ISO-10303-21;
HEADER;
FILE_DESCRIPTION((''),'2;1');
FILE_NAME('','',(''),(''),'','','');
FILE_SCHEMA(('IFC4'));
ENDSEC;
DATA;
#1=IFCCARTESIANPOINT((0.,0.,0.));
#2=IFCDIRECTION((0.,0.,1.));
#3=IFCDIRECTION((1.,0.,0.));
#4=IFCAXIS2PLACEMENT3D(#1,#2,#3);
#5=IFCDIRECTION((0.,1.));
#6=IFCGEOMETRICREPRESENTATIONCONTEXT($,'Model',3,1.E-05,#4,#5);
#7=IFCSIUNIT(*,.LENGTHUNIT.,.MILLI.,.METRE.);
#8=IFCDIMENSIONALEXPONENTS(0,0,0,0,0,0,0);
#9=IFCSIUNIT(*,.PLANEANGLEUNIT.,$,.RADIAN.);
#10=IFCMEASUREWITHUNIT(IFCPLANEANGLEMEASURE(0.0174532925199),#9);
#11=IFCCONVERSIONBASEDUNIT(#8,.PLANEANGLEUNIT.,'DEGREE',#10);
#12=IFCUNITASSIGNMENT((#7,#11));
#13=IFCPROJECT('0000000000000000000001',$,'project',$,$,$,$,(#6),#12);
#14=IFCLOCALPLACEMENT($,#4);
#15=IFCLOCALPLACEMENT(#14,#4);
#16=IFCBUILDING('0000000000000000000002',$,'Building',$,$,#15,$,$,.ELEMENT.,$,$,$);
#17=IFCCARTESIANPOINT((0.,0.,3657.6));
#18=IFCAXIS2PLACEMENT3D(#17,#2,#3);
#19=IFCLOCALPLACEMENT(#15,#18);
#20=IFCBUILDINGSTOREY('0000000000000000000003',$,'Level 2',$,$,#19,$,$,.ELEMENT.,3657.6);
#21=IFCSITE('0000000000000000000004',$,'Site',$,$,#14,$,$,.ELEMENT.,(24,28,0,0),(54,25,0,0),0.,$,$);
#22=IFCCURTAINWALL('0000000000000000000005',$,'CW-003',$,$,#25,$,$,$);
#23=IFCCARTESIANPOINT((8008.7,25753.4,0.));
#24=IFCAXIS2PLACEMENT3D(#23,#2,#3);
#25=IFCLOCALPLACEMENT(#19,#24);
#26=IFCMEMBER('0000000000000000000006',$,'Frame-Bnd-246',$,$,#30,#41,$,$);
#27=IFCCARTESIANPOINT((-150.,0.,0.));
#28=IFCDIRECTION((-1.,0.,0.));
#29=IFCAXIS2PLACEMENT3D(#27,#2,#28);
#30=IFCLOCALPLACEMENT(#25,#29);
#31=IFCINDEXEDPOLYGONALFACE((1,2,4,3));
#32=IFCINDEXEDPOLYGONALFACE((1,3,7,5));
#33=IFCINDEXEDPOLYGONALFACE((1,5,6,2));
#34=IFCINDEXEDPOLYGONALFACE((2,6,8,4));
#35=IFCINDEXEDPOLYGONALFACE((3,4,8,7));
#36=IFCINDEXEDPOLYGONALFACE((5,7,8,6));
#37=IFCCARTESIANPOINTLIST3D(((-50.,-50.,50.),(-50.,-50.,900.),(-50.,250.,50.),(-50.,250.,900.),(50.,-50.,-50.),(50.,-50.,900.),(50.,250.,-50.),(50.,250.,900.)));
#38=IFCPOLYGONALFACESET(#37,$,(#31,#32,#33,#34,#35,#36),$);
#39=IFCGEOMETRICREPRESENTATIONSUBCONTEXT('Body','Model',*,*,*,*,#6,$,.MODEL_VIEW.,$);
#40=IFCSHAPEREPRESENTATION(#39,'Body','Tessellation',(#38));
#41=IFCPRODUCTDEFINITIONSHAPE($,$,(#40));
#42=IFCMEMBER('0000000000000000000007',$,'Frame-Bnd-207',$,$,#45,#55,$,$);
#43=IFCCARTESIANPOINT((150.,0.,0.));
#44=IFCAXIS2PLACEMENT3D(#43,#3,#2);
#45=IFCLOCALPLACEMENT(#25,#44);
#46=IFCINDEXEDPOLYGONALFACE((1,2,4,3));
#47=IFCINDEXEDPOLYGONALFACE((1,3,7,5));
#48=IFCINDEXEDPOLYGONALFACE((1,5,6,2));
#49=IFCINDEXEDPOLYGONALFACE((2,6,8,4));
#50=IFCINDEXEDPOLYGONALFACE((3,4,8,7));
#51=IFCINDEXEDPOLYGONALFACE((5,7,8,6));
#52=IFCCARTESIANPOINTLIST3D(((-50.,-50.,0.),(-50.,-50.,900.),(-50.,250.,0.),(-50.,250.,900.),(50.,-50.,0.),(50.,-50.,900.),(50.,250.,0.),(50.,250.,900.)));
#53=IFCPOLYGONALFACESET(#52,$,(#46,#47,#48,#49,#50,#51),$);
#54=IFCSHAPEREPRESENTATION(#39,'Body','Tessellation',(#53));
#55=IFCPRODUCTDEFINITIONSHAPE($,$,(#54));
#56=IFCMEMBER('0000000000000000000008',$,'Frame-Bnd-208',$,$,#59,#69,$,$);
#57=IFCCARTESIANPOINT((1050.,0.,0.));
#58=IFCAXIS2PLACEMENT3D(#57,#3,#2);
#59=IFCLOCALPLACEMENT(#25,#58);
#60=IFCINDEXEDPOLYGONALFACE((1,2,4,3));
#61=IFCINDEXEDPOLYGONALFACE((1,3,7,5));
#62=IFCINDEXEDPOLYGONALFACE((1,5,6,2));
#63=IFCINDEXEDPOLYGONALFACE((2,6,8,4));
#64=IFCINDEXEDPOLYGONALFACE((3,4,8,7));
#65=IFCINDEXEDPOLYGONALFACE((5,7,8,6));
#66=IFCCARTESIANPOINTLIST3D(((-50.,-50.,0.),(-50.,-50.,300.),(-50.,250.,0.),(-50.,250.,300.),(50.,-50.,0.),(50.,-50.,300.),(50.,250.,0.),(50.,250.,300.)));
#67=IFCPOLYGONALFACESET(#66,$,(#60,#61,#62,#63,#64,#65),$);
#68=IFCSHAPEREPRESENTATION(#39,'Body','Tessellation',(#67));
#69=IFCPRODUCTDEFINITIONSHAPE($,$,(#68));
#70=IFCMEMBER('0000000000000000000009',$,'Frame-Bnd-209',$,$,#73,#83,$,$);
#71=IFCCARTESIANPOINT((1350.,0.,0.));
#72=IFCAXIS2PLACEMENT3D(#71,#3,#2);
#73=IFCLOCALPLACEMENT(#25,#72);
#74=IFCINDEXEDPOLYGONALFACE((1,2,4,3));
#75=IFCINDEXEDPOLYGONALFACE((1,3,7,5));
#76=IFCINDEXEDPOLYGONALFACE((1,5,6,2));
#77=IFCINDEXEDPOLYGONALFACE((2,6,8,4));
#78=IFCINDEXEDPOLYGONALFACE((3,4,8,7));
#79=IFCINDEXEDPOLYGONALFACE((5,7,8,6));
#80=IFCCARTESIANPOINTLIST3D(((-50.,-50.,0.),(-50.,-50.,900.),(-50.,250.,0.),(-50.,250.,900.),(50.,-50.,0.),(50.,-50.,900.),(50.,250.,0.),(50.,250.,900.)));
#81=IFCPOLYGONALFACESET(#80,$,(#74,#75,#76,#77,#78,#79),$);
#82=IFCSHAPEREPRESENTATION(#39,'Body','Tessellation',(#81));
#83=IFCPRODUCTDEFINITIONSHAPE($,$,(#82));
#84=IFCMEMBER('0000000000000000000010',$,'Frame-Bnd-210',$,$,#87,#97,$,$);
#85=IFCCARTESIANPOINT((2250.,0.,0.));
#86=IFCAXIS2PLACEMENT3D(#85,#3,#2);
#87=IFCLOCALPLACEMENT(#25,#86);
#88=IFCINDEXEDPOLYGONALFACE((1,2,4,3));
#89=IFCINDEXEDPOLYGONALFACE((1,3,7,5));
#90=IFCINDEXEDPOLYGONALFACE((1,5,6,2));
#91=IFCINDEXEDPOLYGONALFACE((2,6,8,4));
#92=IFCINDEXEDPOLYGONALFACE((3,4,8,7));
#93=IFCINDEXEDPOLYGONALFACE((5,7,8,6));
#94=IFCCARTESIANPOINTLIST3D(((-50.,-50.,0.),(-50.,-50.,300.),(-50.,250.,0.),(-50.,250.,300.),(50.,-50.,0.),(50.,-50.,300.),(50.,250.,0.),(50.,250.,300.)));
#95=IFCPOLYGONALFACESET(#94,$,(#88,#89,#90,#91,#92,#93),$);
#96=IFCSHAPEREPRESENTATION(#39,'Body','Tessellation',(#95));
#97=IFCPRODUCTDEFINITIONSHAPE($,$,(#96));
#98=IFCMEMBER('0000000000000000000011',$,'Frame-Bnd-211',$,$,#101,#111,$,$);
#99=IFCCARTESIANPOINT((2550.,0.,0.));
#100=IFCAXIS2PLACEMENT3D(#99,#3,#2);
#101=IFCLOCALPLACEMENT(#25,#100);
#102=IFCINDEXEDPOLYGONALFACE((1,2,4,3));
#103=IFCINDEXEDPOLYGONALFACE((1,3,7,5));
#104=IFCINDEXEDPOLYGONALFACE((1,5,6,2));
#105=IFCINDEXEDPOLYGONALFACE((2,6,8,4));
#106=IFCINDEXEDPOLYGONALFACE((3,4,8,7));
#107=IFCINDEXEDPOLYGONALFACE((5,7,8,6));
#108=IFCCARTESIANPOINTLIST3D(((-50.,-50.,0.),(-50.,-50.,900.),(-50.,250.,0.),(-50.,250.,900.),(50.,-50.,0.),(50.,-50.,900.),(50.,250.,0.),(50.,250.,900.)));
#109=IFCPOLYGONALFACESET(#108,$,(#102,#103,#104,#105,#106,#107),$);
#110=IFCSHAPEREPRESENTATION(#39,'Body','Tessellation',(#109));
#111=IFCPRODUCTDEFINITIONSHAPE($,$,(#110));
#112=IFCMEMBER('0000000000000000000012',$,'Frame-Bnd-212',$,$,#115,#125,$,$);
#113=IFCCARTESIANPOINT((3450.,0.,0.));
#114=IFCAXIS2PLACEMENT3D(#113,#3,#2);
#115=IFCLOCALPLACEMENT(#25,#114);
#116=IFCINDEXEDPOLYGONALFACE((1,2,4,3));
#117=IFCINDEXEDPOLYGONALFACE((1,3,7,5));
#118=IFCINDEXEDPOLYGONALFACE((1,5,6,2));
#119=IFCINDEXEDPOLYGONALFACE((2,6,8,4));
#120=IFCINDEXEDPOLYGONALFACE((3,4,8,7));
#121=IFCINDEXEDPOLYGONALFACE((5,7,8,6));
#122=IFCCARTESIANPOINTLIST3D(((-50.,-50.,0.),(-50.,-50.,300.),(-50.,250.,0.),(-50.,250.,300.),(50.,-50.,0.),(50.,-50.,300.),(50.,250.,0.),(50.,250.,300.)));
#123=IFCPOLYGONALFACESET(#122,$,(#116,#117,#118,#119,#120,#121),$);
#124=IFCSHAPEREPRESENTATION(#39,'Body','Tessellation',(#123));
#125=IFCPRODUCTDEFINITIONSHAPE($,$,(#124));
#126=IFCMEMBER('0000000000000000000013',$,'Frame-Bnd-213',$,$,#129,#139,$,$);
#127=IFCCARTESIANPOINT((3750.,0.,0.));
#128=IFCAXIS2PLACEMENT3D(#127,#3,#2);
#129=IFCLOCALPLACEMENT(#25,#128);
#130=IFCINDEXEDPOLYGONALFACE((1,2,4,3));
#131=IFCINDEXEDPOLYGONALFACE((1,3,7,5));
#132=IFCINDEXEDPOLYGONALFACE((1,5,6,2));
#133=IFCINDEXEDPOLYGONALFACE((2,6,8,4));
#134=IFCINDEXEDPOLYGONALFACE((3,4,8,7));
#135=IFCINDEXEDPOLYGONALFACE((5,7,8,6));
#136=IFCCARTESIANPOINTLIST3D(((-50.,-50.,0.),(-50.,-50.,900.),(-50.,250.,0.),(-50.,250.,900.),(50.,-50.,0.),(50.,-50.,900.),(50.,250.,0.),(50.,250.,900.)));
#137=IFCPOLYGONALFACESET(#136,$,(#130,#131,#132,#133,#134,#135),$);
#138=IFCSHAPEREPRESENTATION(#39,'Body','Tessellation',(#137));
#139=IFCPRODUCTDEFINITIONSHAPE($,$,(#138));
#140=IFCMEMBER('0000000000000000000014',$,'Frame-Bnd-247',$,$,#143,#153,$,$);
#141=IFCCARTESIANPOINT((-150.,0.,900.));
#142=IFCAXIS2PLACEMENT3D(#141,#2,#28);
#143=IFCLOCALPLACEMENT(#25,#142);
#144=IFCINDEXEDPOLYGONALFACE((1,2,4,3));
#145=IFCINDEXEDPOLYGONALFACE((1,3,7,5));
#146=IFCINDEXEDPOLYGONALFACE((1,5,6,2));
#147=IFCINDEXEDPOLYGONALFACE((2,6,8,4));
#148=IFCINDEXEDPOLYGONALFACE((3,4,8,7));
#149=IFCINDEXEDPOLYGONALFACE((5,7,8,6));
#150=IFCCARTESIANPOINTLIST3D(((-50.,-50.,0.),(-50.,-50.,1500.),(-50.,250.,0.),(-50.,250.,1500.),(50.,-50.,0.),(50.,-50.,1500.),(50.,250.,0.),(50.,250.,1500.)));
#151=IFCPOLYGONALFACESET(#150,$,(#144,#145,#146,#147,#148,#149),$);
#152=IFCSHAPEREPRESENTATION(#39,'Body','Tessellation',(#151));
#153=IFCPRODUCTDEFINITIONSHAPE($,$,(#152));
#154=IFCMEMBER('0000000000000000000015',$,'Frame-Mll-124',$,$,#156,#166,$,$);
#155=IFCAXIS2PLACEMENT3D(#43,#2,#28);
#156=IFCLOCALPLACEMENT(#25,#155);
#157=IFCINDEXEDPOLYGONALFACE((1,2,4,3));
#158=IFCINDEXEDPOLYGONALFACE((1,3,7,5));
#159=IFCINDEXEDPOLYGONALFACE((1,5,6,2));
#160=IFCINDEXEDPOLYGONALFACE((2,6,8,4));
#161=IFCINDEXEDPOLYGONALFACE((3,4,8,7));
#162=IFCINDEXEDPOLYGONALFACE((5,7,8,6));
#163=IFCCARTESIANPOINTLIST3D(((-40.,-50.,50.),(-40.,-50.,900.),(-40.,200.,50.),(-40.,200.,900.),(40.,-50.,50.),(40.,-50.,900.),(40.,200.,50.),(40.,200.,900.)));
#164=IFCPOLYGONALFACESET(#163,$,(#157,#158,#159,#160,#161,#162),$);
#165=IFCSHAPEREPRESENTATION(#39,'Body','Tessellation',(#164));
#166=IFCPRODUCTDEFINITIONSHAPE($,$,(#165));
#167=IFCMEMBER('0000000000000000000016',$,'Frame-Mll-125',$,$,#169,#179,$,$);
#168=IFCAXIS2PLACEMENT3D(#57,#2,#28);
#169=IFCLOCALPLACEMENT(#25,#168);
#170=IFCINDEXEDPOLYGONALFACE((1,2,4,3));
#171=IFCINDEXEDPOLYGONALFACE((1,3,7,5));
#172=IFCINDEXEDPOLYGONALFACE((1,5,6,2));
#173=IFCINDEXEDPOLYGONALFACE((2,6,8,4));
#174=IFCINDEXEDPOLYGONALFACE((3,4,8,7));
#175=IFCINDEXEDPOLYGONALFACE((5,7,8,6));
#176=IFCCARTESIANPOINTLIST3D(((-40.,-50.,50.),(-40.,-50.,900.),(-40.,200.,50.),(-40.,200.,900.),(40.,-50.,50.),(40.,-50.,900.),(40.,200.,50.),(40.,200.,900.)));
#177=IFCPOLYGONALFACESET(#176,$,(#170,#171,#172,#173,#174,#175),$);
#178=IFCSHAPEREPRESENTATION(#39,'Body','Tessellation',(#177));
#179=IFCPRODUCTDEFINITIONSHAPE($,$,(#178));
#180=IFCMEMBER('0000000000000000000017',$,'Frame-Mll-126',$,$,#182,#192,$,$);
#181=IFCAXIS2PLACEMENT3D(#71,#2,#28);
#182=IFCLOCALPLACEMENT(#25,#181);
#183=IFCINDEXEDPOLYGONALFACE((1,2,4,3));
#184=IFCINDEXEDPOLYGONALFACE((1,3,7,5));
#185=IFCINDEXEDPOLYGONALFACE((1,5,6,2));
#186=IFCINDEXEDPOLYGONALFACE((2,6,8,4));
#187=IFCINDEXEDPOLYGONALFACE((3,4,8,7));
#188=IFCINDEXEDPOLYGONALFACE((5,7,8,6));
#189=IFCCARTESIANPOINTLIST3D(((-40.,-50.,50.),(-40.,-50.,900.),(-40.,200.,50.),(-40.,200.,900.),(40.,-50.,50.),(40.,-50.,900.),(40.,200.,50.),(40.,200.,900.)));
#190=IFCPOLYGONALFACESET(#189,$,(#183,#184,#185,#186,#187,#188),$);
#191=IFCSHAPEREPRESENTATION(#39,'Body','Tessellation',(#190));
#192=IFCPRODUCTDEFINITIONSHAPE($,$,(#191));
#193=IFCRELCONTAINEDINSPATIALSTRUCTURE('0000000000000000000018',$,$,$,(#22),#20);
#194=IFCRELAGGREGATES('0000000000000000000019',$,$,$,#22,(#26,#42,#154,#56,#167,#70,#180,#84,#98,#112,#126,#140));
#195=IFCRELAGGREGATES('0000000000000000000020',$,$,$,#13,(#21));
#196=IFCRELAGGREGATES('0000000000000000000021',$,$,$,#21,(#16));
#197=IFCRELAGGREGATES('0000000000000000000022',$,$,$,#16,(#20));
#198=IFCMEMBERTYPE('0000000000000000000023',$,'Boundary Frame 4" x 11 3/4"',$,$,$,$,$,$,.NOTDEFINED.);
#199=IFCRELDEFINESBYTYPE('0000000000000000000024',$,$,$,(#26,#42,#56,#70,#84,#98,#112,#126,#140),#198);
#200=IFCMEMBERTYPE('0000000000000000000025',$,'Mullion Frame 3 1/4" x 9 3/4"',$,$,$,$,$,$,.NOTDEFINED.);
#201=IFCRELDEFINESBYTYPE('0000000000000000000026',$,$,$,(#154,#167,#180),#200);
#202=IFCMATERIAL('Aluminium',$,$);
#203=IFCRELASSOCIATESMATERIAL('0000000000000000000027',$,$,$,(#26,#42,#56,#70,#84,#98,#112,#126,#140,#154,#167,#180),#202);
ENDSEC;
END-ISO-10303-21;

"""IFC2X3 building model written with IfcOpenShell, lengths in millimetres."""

from ifc_helpers import new_model, entity, si_unit, converted_unit, direction, frame, origin_with_axes, place, context, subcontext, project, spatial, polyline, outline, extrude, clip, halfspace, material, type_object, element, aggregate, save


model = new_model("IFC2X3")

# Units and contexts
model_context = context("Model", 3, precision=1e-05, world=origin_with_axes(), true_north=direction((0.0, 1.0)))
body_context = subcontext(model_context, "Body", "Model", "MODEL_VIEW")
ifc_project = project(units=[si_unit("LENGTHUNIT", "METRE", prefix="MILLI"), converted_unit("PLANEANGLEUNIT", "DEGREE", entity("IfcPlaneAngleMeasure", 0.0174532925199), si_unit("PLANEANGLEUNIT", "RADIAN"), dimensions=[0, 0, 0, 0, 0, 0, 0])], contexts=[model_context])

# Site, building, storey
site_placement = place(None, origin_with_axes())
site = spatial("IfcSite", under=ifc_project, at=site_placement, Name="Site", CompositionType="ELEMENT", RefLatitude=(24, 28, 0, 0), RefLongitude=(54, 25, 0, 0), RefElevation=0.0)
building_placement = place(site_placement, origin_with_axes())
building = spatial("IfcBuilding", under=site, at=building_placement, Name="Building", CompositionType="ELEMENT")
storey_placement = place(building_placement, frame((0.0, 0.0, 3657.6), z_axis=(0.0, 0.0, 1.0), x_axis=(1.0, 0.0, 0.0)))
storey = spatial("IfcBuildingStorey", under=building, at=storey_placement, Name="Level 2", CompositionType="ELEMENT", Elevation=3657.6)

# Curtain wall, members
curtain_wall_placement = place(storey_placement, frame((8008.7, 25753.4, 0.0), z_axis=(0.0, 0.0, 1.0), x_axis=(1.0, 0.0, 0.0)))
curtain_wall = element("IfcCurtainWall", 1, at=curtain_wall_placement, inside=storey, Name="CW-003")
ifc_material_1 = material(Name="Aluminium")
member_type_1 = type_object("IfcMemberType", Name="Boundary Frame 4\" x 11 3/4\"", PredefinedType="NOTDEFINED")
member_1_placement = place(curtain_wall_placement, frame((-150.0, 0.0, 0.0), z_axis=(0.0, 0.0, 1.0), x_axis=(-1.0, 0.0, 0.0)))
member_1 = element("IfcMember", 2, at=member_1_placement, type_object=member_type_1, material=ifc_material_1, Name="Frame-Bnd-246", context=body_context, shape_type="Clipping", body=[
    clip(extrude(outline(polyline([(-50.0, -250.0), (50.0, -250.0), (50.0, 50.0), (-50.0, 50.0), (-50.0, -250.0)])), frame((0.0, 0.0, -50.0), z_axis=(0.0, 0.0, 1.0), x_axis=(-1.0, 0.0, 0.0)), (0.0, 0.0, 1.0), 950.0), halfspace(frame((0.0, 0.0, 0.0), z_axis=(0.707107, 0.0, 0.707107), x_axis=(0.0, -1.0, 0.0)), True)),
])
member_2_placement = place(curtain_wall_placement, frame((150.0, 0.0, 0.0), z_axis=(1.0, 0.0, 0.0), x_axis=(0.0, 0.0, 1.0)))
member_2 = element("IfcMember", 3, at=member_2_placement, type_object=member_type_1, material=ifc_material_1, Name="Frame-Bnd-207", context=body_context, shape_type="SweptSolid", body=[
    extrude(outline(polyline([(250.0, -50.0), (250.0, 50.0), (-50.0, 50.0), (-50.0, -50.0), (250.0, -50.0)])), frame((0.0, 0.0, 0.0), z_axis=(0.0, 0.0, 1.0), x_axis=(0.0, 1.0, 0.0)), (0.0, 0.0, 1.0), 900.0),
])
member_3_placement = place(curtain_wall_placement, frame((1050.0, 0.0, 0.0), z_axis=(1.0, 0.0, 0.0), x_axis=(0.0, 0.0, 1.0)))
member_3 = element("IfcMember", 4, at=member_3_placement, type_object=member_type_1, material=ifc_material_1, Name="Frame-Bnd-208", context=body_context, shape_type="SweptSolid", body=[
    extrude(outline(polyline([(250.0, -50.0), (250.0, 50.0), (-50.0, 50.0), (-50.0, -50.0), (250.0, -50.0)])), frame((0.0, 0.0, 0.0), z_axis=(0.0, 0.0, 1.0), x_axis=(0.0, 1.0, 0.0)), (0.0, 0.0, 1.0), 300.0),
])
member_4_placement = place(curtain_wall_placement, frame((1350.0, 0.0, 0.0), z_axis=(1.0, 0.0, 0.0), x_axis=(0.0, 0.0, 1.0)))
member_4 = element("IfcMember", 5, at=member_4_placement, type_object=member_type_1, material=ifc_material_1, Name="Frame-Bnd-209", context=body_context, shape_type="SweptSolid", body=[
    extrude(outline(polyline([(250.0, -50.0), (250.0, 50.0), (-50.0, 50.0), (-50.0, -50.0), (250.0, -50.0)])), frame((0.0, 0.0, 0.0), z_axis=(0.0, 0.0, 1.0), x_axis=(0.0, 1.0, 0.0)), (0.0, 0.0, 1.0), 900.0),
])
member_5_placement = place(curtain_wall_placement, frame((2250.0, 0.0, 0.0), z_axis=(1.0, 0.0, 0.0), x_axis=(0.0, 0.0, 1.0)))
member_5 = element("IfcMember", 6, at=member_5_placement, type_object=member_type_1, material=ifc_material_1, Name="Frame-Bnd-210", context=body_context, shape_type="SweptSolid", body=[
    extrude(outline(polyline([(250.0, -50.0), (250.0, 50.0), (-50.0, 50.0), (-50.0, -50.0), (250.0, -50.0)])), frame((0.0, 0.0, 0.0), z_axis=(0.0, 0.0, 1.0), x_axis=(0.0, 1.0, 0.0)), (0.0, 0.0, 1.0), 300.0),
])
member_6_placement = place(curtain_wall_placement, frame((2550.0, 0.0, 0.0), z_axis=(1.0, 0.0, 0.0), x_axis=(0.0, 0.0, 1.0)))
member_6 = element("IfcMember", 7, at=member_6_placement, type_object=member_type_1, material=ifc_material_1, Name="Frame-Bnd-211", context=body_context, shape_type="SweptSolid", body=[
    extrude(outline(polyline([(250.0, -50.0), (250.0, 50.0), (-50.0, 50.0), (-50.0, -50.0), (250.0, -50.0)])), frame((0.0, 0.0, 0.0), z_axis=(0.0, 0.0, 1.0), x_axis=(0.0, 1.0, 0.0)), (0.0, 0.0, 1.0), 900.0),
])
member_7_placement = place(curtain_wall_placement, frame((3450.0, 0.0, 0.0), z_axis=(1.0, 0.0, 0.0), x_axis=(0.0, 0.0, 1.0)))
member_7 = element("IfcMember", 8, at=member_7_placement, type_object=member_type_1, material=ifc_material_1, Name="Frame-Bnd-212", context=body_context, shape_type="SweptSolid", body=[
    extrude(outline(polyline([(250.0, -50.0), (250.0, 50.0), (-50.0, 50.0), (-50.0, -50.0), (250.0, -50.0)])), frame((0.0, 0.0, 0.0), z_axis=(0.0, 0.0, 1.0), x_axis=(0.0, 1.0, 0.0)), (0.0, 0.0, 1.0), 300.0),
])
member_8_placement = place(curtain_wall_placement, frame((3750.0, 0.0, 0.0), z_axis=(1.0, 0.0, 0.0), x_axis=(0.0, 0.0, 1.0)))
member_8 = element("IfcMember", 9, at=member_8_placement, type_object=member_type_1, material=ifc_material_1, Name="Frame-Bnd-213", context=body_context, shape_type="SweptSolid", body=[
    extrude(outline(polyline([(250.0, -50.0), (250.0, 50.0), (-50.0, 50.0), (-50.0, -50.0), (250.0, -50.0)])), frame((0.0, 0.0, 0.0), z_axis=(0.0, 0.0, 1.0), x_axis=(0.0, 1.0, 0.0)), (0.0, 0.0, 1.0), 900.0),
])
member_9_placement = place(curtain_wall_placement, frame((-150.0, 0.0, 900.0), z_axis=(0.0, 0.0, 1.0), x_axis=(-1.0, 0.0, 0.0)))
member_9 = element("IfcMember", 10, at=member_9_placement, type_object=member_type_1, material=ifc_material_1, Name="Frame-Bnd-247", context=body_context, shape_type="SweptSolid", body=[
    extrude(outline(polyline([(-50.0, -250.0), (50.0, -250.0), (50.0, 50.0), (-50.0, 50.0), (-50.0, -250.0)])), frame((0.0, 0.0, 0.0), z_axis=(0.0, 0.0, 1.0), x_axis=(-1.0, 0.0, 0.0)), (0.0, 0.0, 1.0), 1500.0),
])
member_type_2 = type_object("IfcMemberType", Name="Mullion Frame 3 1/4\" x 9 3/4\"", PredefinedType="NOTDEFINED")
member_10_placement = place(curtain_wall_placement, frame((150.0, 0.0, 0.0), z_axis=(0.0, 0.0, 1.0), x_axis=(-1.0, 0.0, 0.0)))
member_10 = element("IfcMember", 11, at=member_10_placement, type_object=member_type_2, material=ifc_material_1, Name="Frame-Mll-124", context=body_context, shape_type="SweptSolid", body=[
    extrude(outline(polyline([(-40.0, -200.0), (40.0, -200.0), (40.0, 50.0), (-40.0, 50.0), (-40.0, -200.0)])), frame((0.0, 0.0, 50.0), z_axis=(0.0, 0.0, 1.0), x_axis=(-1.0, 0.0, 0.0)), (0.0, 0.0, 1.0), 850.0),
])
member_11_placement = place(curtain_wall_placement, frame((1050.0, 0.0, 0.0), z_axis=(0.0, 0.0, 1.0), x_axis=(-1.0, 0.0, 0.0)))
member_11 = element("IfcMember", 12, at=member_11_placement, type_object=member_type_2, material=ifc_material_1, Name="Frame-Mll-125", context=body_context, shape_type="SweptSolid", body=[
    extrude(outline(polyline([(-40.0, -200.0), (40.0, -200.0), (40.0, 50.0), (-40.0, 50.0), (-40.0, -200.0)])), frame((0.0, 0.0, 50.0), z_axis=(0.0, 0.0, 1.0), x_axis=(-1.0, 0.0, 0.0)), (0.0, 0.0, 1.0), 850.0),
])
member_12_placement = place(curtain_wall_placement, frame((1350.0, 0.0, 0.0), z_axis=(0.0, 0.0, 1.0), x_axis=(-1.0, 0.0, 0.0)))
member_12 = element("IfcMember", 13, at=member_12_placement, type_object=member_type_2, material=ifc_material_1, Name="Frame-Mll-126", context=body_context, shape_type="SweptSolid", body=[
    extrude(outline(polyline([(-40.0, -200.0), (40.0, -200.0), (40.0, 50.0), (-40.0, 50.0), (-40.0, -200.0)])), frame((0.0, 0.0, 50.0), z_axis=(0.0, 0.0, 1.0), x_axis=(-1.0, 0.0, 0.0)), (0.0, 0.0, 1.0), 850.0),
])
aggregate(curtain_wall, [member_1, member_2, member_10, member_3, member_11, member_4, member_12, member_5, member_6, member_7, member_8, member_9])

save(model, "model.ifc")
